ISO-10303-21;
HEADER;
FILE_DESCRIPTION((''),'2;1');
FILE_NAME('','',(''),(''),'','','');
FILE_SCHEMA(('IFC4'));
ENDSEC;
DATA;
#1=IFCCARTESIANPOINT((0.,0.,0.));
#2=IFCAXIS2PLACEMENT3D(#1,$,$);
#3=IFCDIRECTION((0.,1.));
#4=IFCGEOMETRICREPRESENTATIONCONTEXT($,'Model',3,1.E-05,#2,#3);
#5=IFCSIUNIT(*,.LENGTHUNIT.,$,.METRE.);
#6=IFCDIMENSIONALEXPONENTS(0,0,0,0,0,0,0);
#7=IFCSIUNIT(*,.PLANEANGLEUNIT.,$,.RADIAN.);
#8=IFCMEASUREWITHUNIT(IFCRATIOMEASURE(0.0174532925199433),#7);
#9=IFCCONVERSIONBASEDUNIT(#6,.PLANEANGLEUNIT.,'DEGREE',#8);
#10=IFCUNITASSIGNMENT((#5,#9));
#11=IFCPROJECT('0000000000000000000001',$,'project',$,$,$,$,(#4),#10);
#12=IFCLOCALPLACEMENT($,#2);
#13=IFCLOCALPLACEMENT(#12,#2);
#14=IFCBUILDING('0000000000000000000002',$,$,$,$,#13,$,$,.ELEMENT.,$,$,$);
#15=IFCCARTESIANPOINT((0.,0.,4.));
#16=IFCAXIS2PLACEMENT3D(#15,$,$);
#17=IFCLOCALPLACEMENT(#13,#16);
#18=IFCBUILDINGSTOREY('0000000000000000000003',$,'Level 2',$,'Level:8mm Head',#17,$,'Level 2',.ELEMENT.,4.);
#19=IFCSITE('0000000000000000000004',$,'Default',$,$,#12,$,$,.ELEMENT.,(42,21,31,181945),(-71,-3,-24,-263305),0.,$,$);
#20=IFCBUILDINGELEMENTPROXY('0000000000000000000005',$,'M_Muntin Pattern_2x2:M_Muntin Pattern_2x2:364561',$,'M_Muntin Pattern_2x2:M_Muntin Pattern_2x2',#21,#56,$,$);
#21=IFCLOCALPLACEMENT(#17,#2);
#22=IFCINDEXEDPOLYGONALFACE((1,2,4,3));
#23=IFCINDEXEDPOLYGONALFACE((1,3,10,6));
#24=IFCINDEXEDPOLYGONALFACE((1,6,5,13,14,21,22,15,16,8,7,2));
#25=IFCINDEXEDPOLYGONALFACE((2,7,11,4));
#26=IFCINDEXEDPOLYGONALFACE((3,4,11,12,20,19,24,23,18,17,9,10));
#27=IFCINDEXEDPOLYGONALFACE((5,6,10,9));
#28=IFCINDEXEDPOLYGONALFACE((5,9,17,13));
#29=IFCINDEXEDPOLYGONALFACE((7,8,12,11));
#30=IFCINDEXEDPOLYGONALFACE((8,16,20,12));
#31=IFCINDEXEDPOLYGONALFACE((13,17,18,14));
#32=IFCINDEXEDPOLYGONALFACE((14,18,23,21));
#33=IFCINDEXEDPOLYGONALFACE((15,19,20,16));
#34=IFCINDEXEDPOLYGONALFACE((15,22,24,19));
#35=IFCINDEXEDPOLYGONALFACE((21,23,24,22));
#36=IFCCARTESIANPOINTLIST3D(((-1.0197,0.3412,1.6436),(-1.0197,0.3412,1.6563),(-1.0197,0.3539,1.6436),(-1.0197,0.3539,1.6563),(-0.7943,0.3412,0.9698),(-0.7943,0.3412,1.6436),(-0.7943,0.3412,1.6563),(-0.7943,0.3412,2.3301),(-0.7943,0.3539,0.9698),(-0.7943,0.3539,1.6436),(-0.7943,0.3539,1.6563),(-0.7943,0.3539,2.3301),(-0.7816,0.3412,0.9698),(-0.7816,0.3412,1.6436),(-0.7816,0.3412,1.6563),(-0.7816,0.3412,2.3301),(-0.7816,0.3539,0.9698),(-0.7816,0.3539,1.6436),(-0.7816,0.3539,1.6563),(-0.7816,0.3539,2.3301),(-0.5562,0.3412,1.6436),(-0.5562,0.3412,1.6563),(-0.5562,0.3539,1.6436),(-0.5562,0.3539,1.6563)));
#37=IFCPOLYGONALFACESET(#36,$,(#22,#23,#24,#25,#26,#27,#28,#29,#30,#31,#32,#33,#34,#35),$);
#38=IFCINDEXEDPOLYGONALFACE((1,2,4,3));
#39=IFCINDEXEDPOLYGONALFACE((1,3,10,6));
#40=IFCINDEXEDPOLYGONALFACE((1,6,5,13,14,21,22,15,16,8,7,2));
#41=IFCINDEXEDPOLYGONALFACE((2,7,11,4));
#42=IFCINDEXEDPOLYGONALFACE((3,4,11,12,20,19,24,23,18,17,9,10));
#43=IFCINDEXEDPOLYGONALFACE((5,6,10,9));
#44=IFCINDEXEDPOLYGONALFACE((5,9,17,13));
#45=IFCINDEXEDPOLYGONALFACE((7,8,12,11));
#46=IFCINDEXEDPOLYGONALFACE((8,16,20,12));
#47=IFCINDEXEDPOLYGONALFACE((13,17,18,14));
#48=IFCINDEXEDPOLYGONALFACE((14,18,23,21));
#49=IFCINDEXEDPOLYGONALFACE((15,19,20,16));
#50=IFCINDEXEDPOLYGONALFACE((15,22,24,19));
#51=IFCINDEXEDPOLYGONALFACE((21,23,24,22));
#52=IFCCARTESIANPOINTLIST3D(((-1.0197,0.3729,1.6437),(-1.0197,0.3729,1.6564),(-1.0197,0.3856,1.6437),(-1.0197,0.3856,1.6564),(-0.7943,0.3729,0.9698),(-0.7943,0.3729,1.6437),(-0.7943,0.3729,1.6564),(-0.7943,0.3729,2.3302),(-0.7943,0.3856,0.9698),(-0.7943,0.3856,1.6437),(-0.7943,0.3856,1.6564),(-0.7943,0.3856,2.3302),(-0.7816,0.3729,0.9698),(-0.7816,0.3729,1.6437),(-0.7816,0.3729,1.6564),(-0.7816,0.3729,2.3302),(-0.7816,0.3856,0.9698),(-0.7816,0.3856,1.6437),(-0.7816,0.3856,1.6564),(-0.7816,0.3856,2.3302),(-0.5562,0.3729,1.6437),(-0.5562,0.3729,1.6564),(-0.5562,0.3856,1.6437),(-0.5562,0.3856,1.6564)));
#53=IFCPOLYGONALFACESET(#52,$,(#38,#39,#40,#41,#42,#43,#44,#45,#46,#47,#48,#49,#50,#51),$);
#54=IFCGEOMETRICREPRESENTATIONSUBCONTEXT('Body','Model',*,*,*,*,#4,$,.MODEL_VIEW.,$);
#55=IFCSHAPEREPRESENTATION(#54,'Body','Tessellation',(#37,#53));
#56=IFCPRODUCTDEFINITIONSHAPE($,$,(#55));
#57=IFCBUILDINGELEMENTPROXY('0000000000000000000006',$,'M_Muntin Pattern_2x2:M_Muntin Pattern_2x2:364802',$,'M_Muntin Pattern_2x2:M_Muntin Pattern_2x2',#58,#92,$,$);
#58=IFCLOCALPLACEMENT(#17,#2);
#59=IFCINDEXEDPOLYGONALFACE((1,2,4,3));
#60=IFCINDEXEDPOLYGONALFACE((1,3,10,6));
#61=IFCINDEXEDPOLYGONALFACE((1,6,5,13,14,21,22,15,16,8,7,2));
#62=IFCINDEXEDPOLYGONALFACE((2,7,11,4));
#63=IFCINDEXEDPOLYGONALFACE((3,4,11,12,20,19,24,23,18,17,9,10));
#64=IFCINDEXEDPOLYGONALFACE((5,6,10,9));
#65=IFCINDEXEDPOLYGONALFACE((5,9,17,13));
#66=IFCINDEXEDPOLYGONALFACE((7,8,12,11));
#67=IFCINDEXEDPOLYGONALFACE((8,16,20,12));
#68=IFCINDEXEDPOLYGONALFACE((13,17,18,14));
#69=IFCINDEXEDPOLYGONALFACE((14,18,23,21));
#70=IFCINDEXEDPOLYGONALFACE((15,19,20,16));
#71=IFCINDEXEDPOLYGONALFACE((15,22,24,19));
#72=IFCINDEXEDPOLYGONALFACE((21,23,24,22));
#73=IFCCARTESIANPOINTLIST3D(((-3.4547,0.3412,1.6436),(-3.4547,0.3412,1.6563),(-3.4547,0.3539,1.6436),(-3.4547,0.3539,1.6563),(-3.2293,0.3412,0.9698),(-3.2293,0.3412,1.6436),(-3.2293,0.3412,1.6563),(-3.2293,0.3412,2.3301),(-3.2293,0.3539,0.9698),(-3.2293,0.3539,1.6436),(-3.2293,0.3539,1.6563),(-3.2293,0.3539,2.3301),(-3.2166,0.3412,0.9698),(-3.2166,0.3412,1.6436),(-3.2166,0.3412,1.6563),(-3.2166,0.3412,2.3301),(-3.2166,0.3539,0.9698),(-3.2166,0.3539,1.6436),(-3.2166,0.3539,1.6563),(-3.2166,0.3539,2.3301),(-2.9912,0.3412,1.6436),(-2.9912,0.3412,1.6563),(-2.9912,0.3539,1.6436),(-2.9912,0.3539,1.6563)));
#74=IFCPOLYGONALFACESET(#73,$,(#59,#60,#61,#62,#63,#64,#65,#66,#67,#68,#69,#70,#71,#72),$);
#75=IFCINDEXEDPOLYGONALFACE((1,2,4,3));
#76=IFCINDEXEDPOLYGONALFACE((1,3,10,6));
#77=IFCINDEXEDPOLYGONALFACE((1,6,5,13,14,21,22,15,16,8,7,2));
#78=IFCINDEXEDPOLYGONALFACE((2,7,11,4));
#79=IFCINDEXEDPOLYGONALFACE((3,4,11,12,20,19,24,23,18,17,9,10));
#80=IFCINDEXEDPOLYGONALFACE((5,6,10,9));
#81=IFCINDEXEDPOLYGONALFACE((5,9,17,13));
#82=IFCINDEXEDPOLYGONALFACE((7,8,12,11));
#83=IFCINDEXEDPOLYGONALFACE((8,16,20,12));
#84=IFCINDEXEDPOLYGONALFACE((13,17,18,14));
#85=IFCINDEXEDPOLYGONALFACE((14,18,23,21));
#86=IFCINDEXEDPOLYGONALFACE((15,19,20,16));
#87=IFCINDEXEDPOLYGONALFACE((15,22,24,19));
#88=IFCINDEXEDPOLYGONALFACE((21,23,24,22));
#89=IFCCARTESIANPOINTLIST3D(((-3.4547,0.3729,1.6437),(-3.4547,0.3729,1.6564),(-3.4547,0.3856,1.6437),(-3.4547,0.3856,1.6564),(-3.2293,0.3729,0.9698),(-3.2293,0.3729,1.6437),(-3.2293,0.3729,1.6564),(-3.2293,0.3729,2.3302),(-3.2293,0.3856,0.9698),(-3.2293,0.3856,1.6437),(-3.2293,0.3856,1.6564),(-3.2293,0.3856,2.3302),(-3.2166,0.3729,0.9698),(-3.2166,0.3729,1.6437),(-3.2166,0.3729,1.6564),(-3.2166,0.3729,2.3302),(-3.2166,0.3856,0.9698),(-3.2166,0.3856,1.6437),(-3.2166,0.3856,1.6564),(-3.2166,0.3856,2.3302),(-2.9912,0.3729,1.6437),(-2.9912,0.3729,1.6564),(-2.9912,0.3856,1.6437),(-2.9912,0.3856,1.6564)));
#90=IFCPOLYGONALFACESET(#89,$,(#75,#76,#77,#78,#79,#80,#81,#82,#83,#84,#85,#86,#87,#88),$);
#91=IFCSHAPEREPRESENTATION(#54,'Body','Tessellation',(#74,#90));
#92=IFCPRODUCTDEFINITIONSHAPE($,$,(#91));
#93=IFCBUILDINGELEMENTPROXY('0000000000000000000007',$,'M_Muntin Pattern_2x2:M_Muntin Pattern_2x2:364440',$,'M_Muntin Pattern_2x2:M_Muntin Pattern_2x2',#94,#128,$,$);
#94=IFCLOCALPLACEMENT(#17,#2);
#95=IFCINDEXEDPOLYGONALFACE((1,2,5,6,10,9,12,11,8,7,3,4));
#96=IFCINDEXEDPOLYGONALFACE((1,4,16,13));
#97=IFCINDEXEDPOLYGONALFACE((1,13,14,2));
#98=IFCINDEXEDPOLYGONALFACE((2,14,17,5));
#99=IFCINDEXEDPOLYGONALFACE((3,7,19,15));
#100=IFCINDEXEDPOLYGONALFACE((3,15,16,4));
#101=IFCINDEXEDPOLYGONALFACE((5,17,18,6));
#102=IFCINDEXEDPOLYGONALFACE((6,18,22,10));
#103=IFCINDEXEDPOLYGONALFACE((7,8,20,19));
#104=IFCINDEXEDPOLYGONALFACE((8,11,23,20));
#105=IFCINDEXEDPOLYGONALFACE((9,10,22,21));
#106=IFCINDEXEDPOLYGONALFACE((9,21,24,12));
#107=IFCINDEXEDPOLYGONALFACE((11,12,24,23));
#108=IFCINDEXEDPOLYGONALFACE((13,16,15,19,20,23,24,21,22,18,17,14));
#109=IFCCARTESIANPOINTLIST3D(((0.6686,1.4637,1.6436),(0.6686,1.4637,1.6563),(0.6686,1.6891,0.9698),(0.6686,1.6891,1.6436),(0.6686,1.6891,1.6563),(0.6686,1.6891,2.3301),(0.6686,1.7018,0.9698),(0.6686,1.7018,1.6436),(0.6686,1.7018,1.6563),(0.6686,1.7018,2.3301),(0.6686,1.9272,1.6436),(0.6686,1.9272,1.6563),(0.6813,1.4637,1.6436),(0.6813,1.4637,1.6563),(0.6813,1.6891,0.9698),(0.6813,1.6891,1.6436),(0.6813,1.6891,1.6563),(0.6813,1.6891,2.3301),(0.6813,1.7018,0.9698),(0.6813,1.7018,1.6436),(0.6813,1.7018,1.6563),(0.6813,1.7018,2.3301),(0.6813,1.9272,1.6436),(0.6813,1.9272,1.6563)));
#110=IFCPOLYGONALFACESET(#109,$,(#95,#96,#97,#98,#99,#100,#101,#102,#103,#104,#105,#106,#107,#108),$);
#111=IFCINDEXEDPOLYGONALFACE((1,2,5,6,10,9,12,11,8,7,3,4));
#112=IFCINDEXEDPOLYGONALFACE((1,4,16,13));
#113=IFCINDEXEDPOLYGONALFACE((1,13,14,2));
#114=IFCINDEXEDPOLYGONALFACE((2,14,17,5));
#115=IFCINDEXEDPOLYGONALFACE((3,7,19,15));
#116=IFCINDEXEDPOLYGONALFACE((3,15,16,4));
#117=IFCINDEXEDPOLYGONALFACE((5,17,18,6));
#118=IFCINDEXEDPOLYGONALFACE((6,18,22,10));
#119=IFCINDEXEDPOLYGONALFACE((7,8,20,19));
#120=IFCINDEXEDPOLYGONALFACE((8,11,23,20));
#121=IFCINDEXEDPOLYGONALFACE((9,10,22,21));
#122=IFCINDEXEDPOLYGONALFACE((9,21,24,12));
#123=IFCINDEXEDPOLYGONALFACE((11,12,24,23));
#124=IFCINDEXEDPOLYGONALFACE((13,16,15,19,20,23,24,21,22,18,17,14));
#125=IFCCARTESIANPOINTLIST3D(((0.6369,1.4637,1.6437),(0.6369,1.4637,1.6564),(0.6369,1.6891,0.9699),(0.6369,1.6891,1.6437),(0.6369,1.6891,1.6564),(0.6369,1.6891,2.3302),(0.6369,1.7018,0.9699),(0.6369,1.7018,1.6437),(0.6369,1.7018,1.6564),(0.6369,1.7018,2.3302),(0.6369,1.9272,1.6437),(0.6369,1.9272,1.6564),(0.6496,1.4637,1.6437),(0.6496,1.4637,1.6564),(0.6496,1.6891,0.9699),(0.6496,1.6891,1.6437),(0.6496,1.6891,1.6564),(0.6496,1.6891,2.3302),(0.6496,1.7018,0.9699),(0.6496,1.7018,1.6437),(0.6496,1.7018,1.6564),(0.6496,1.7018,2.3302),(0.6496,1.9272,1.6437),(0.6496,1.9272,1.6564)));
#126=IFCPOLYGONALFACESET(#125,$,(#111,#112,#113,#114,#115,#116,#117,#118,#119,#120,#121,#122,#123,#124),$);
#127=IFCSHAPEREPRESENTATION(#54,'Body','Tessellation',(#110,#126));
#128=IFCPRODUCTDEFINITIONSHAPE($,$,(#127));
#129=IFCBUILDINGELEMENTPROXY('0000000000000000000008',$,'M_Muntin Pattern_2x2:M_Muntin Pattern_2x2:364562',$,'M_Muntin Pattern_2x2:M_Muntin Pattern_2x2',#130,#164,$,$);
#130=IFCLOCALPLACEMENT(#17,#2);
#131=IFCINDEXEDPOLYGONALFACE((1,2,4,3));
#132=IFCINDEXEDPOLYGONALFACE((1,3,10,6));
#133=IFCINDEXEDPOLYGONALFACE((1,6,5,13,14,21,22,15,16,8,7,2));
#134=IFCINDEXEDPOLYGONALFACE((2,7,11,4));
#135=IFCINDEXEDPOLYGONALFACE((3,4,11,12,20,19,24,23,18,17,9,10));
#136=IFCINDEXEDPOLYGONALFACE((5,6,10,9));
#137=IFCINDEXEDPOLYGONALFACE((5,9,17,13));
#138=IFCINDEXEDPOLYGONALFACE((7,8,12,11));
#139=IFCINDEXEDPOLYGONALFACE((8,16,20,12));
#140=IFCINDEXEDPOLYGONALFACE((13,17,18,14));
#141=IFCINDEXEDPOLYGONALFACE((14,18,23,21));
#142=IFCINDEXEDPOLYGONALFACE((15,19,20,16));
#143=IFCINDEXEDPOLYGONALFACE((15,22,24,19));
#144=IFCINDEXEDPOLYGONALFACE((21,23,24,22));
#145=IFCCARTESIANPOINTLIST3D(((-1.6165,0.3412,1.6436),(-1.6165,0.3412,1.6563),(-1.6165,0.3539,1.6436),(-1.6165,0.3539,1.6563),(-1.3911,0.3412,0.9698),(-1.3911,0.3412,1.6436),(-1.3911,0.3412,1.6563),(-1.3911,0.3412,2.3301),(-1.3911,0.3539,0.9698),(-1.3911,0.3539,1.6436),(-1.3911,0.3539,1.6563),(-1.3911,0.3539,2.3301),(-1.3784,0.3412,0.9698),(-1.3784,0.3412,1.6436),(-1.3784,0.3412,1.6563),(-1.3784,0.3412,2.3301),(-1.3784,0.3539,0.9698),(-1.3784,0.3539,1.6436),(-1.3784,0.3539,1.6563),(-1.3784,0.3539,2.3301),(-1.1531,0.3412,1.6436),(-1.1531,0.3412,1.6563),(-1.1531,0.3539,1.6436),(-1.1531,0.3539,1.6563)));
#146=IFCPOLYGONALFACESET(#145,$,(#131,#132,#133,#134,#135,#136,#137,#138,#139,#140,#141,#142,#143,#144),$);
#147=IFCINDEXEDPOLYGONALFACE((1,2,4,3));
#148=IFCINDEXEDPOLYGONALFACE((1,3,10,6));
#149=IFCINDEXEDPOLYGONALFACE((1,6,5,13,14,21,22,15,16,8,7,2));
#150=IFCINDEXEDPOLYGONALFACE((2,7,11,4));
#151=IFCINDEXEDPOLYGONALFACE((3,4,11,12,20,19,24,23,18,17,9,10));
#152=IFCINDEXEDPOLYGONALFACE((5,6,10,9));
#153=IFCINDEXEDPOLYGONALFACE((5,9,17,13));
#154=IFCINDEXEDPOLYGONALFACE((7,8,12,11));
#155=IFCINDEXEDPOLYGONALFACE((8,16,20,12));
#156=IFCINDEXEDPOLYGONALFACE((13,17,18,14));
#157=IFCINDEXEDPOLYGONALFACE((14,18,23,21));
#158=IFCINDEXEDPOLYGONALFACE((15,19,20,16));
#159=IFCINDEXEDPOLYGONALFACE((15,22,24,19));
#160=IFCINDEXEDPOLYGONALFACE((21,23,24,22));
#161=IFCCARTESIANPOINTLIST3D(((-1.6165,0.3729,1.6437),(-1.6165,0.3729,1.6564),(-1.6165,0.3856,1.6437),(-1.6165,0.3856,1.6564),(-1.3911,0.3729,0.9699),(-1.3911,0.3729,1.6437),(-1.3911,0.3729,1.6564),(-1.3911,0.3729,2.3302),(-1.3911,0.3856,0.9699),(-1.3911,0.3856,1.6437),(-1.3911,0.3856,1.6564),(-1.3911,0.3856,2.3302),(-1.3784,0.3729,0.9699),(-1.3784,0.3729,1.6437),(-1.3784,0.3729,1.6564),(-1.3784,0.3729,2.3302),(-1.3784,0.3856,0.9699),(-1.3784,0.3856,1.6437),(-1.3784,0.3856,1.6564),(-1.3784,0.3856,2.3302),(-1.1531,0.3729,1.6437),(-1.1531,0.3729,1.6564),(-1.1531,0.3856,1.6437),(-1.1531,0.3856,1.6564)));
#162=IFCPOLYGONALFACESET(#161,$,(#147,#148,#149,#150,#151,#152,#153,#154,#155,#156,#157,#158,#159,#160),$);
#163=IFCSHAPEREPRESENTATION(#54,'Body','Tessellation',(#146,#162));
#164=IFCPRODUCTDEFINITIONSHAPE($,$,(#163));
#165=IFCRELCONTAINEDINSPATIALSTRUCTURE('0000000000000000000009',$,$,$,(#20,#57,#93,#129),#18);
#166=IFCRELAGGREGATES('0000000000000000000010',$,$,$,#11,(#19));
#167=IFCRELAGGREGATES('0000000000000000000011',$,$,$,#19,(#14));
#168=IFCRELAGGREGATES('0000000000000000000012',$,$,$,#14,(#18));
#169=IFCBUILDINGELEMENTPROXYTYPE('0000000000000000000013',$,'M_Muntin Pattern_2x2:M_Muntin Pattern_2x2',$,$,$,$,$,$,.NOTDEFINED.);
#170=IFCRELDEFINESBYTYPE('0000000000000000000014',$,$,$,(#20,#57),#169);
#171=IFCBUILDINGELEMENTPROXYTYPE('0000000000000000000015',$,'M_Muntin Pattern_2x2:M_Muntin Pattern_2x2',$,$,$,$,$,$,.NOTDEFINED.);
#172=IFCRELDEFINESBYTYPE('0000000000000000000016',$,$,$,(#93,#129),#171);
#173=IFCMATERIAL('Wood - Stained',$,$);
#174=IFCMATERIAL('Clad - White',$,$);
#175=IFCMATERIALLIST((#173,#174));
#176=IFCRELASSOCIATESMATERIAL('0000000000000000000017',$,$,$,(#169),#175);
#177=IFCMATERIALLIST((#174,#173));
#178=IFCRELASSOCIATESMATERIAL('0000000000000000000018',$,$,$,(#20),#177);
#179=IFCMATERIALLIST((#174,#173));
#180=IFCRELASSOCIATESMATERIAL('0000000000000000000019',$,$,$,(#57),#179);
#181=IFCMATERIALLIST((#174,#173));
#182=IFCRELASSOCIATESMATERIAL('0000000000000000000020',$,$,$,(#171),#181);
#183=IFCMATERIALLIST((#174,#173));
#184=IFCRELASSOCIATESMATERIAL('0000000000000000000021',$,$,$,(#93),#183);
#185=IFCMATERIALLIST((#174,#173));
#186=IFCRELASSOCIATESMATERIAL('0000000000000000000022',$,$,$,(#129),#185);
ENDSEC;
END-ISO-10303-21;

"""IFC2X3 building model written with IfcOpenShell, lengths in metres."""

from ifc_helpers import new_model, entity, si_unit, converted_unit, direction, frame, origin, place, context, subcontext, project, spatial, polyline, outline, extrude, source, transform, mapped, material, material_list, type_object, type_shapes, element, save


model = new_model("IFC2X3")

# Units and contexts
model_context = context("Model", 3, precision=1e-05, world=origin(), true_north=direction((0.0, 1.0)))
body_context = subcontext(model_context, "Body", "Model", "MODEL_VIEW")
ifc_project = project(units=[si_unit("LENGTHUNIT", "METRE"), converted_unit("PLANEANGLEUNIT", "DEGREE", entity("IfcRatioMeasure", 0.0174532925199433), si_unit("PLANEANGLEUNIT", "RADIAN"), dimensions=[0, 0, 0, 0, 0, 0, 0])], contexts=[model_context])

# Site, building, storey
site_placement = place(None, origin())
site = spatial("IfcSite", under=ifc_project, at=site_placement, Name="Default", CompositionType="ELEMENT", RefLatitude=(42, 21, 31, 181945), RefLongitude=(-71, -3, -24, -263305), RefElevation=0.0)
building_placement = place(site_placement, origin())
building = spatial("IfcBuilding", under=site, at=building_placement, CompositionType="ELEMENT")
storey_placement = place(building_placement, frame((0.0, 0.0, 4.0)))
storey = spatial("IfcBuildingStorey", under=building, at=storey_placement, Name="Level 2", ObjectType="Level:8mm Head", LongName="Level 2", CompositionType="ELEMENT", Elevation=4.0)

# Building element proxies
ifc_material_1 = material(Name="Clad - White")
ifc_material_2 = material(Name="Wood - Stained")
ifc_material_list_1 = material_list([ifc_material_2, ifc_material_1])
building_element_proxy_type_1 = type_object("IfcBuildingElementProxyType", Name="M_Muntin Pattern_2x2:M_Muntin Pattern_2x2", PredefinedType="NOTDEFINED", material=ifc_material_list_1)
shared_shape_1 = source(origin(), body_context, "Body", "SweptSolid", [
    extrude(outline(polyline([(0.0064, -0.0064), (0.6801, -0.0064), (0.6801, 0.0063), (0.0064, 0.0063), (0.0064, 0.2317), (-0.0063, 0.2317), (-0.0063, 0.0063), (-0.6802, 0.0063), (-0.6802, -0.0064), (-0.0063, -0.0064), (-0.0063, -0.2317), (0.0064, -0.2317), (0.0064, -0.0064)])), frame((0.0, 0.0095, 0.6801), z_axis=(0.0, 1.0, 0.0), x_axis=(0.0, 0.0, 1.0)), (0.0, 0.0, 1.0), 0.0127),
    extrude(outline(polyline([(0.0064, -0.0064), (0.6802, -0.0064), (0.6802, 0.0063), (0.0064, 0.0063), (0.0064, 0.2317), (-0.0063, 0.2317), (-0.0063, 0.0063), (-0.6802, 0.0063), (-0.6802, -0.0064), (-0.0063, -0.0064), (-0.0063, -0.2317), (0.0064, -0.2317), (0.0064, -0.0064)])), frame((0.0, -0.0222, 0.6802), z_axis=(0.0, 1.0, 0.0), x_axis=(0.0, 0.0, 1.0)), (0.0, 0.0, 1.0), 0.0127),
])
type_shapes(building_element_proxy_type_1, [shared_shape_1])
ifc_material_list_2 = material_list([ifc_material_1, ifc_material_2])
proxy_1_placement = place(storey_placement, frame((-0.788, 0.3634, 0.9698), z_axis=(0.0, 0.0, 1.0), x_axis=(-1.0, 0.0, 0.0)))
element("IfcBuildingElementProxy", 1, at=proxy_1_placement, inside=storey, type_object=building_element_proxy_type_1, material=ifc_material_list_2, Name="M_Muntin Pattern_2x2:M_Muntin Pattern_2x2:364561", ObjectType="M_Muntin Pattern_2x2:M_Muntin Pattern_2x2", context=body_context, shape_type="MappedRepresentation", body=[
    mapped(shared_shape_1, transform((0.0, 0.0, 0.0), scale=1.0)),
])
ifc_material_list_3 = material_list([ifc_material_1, ifc_material_2])
proxy_2_placement = place(storey_placement, frame((-3.223, 0.3634, 0.9698), z_axis=(0.0, 0.0, 1.0), x_axis=(-1.0, 0.0, 0.0)))
element("IfcBuildingElementProxy", 2, at=proxy_2_placement, inside=storey, type_object=building_element_proxy_type_1, material=ifc_material_list_3, Name="M_Muntin Pattern_2x2:M_Muntin Pattern_2x2:364802", ObjectType="M_Muntin Pattern_2x2:M_Muntin Pattern_2x2", context=body_context, shape_type="MappedRepresentation", body=[
    mapped(shared_shape_1, transform((0.0, 0.0, 0.0), scale=1.0)),
])
ifc_material_list_4 = material_list([ifc_material_1, ifc_material_2])
ifc_material_list_5 = material_list([ifc_material_1, ifc_material_2])
building_element_proxy_type_2 = type_object("IfcBuildingElementProxyType", Name="M_Muntin Pattern_2x2:M_Muntin Pattern_2x2", PredefinedType="NOTDEFINED", material=ifc_material_list_5)
shared_shape_2 = source(origin(), body_context, "Body", "SweptSolid", [
    extrude(outline(polyline([(0.0064, -0.0064), (0.6801, -0.0064), (0.6801, 0.0063), (0.0064, 0.0063), (0.0064, 0.2317), (-0.0063, 0.2317), (-0.0063, 0.0063), (-0.6802, 0.0063), (-0.6802, -0.0064), (-0.0063, -0.0064), (-0.0063, -0.2317), (0.0064, -0.2317), (0.0064, -0.0064)])), frame((0.0, -0.0222, 0.6801), z_axis=(0.0, 1.0, 0.0), x_axis=(0.0, 0.0, 1.0)), (0.0, 0.0, 1.0), 0.0127),
    extrude(outline(polyline([(0.0064, -0.0064), (0.6802, -0.0064), (0.6802, 0.0063), (0.0064, 0.0063), (0.0064, 0.2317), (-0.0063, 0.2317), (-0.0063, 0.0063), (-0.6802, 0.0063), (-0.6802, -0.0064), (-0.0063, -0.0064), (-0.0063, -0.2317), (0.0064, -0.2317), (0.0064, -0.0064)])), frame((0.0, 0.0095, 0.6802), z_axis=(0.0, 1.0, 0.0), x_axis=(0.0, 0.0, 1.0)), (0.0, 0.0, 1.0), 0.0127),
])
type_shapes(building_element_proxy_type_2, [shared_shape_2])
proxy_3_placement = place(storey_placement, frame((0.6591, 1.6954, 0.9699), z_axis=(0.0, 0.0, 1.0), x_axis=(0.0, 1.0, 0.0)))
element("IfcBuildingElementProxy", 3, at=proxy_3_placement, inside=storey, type_object=building_element_proxy_type_2, material=ifc_material_list_4, Name="M_Muntin Pattern_2x2:M_Muntin Pattern_2x2:364440", ObjectType="M_Muntin Pattern_2x2:M_Muntin Pattern_2x2", context=body_context, shape_type="MappedRepresentation", body=[
    mapped(shared_shape_2, transform((0.0, 0.0, 0.0), scale=1.0)),
])
ifc_material_list_6 = material_list([ifc_material_1, ifc_material_2])
proxy_4_placement = place(storey_placement, frame((-1.3848, 0.3634, 0.9699)))
element("IfcBuildingElementProxy", 4, at=proxy_4_placement, inside=storey, type_object=building_element_proxy_type_2, material=ifc_material_list_6, Name="M_Muntin Pattern_2x2:M_Muntin Pattern_2x2:364562", ObjectType="M_Muntin Pattern_2x2:M_Muntin Pattern_2x2", context=body_context, shape_type="MappedRepresentation", body=[
    mapped(shared_shape_2, transform((0.0, 0.0, 0.0), scale=1.0)),
])

save(model, "model.ifc")
